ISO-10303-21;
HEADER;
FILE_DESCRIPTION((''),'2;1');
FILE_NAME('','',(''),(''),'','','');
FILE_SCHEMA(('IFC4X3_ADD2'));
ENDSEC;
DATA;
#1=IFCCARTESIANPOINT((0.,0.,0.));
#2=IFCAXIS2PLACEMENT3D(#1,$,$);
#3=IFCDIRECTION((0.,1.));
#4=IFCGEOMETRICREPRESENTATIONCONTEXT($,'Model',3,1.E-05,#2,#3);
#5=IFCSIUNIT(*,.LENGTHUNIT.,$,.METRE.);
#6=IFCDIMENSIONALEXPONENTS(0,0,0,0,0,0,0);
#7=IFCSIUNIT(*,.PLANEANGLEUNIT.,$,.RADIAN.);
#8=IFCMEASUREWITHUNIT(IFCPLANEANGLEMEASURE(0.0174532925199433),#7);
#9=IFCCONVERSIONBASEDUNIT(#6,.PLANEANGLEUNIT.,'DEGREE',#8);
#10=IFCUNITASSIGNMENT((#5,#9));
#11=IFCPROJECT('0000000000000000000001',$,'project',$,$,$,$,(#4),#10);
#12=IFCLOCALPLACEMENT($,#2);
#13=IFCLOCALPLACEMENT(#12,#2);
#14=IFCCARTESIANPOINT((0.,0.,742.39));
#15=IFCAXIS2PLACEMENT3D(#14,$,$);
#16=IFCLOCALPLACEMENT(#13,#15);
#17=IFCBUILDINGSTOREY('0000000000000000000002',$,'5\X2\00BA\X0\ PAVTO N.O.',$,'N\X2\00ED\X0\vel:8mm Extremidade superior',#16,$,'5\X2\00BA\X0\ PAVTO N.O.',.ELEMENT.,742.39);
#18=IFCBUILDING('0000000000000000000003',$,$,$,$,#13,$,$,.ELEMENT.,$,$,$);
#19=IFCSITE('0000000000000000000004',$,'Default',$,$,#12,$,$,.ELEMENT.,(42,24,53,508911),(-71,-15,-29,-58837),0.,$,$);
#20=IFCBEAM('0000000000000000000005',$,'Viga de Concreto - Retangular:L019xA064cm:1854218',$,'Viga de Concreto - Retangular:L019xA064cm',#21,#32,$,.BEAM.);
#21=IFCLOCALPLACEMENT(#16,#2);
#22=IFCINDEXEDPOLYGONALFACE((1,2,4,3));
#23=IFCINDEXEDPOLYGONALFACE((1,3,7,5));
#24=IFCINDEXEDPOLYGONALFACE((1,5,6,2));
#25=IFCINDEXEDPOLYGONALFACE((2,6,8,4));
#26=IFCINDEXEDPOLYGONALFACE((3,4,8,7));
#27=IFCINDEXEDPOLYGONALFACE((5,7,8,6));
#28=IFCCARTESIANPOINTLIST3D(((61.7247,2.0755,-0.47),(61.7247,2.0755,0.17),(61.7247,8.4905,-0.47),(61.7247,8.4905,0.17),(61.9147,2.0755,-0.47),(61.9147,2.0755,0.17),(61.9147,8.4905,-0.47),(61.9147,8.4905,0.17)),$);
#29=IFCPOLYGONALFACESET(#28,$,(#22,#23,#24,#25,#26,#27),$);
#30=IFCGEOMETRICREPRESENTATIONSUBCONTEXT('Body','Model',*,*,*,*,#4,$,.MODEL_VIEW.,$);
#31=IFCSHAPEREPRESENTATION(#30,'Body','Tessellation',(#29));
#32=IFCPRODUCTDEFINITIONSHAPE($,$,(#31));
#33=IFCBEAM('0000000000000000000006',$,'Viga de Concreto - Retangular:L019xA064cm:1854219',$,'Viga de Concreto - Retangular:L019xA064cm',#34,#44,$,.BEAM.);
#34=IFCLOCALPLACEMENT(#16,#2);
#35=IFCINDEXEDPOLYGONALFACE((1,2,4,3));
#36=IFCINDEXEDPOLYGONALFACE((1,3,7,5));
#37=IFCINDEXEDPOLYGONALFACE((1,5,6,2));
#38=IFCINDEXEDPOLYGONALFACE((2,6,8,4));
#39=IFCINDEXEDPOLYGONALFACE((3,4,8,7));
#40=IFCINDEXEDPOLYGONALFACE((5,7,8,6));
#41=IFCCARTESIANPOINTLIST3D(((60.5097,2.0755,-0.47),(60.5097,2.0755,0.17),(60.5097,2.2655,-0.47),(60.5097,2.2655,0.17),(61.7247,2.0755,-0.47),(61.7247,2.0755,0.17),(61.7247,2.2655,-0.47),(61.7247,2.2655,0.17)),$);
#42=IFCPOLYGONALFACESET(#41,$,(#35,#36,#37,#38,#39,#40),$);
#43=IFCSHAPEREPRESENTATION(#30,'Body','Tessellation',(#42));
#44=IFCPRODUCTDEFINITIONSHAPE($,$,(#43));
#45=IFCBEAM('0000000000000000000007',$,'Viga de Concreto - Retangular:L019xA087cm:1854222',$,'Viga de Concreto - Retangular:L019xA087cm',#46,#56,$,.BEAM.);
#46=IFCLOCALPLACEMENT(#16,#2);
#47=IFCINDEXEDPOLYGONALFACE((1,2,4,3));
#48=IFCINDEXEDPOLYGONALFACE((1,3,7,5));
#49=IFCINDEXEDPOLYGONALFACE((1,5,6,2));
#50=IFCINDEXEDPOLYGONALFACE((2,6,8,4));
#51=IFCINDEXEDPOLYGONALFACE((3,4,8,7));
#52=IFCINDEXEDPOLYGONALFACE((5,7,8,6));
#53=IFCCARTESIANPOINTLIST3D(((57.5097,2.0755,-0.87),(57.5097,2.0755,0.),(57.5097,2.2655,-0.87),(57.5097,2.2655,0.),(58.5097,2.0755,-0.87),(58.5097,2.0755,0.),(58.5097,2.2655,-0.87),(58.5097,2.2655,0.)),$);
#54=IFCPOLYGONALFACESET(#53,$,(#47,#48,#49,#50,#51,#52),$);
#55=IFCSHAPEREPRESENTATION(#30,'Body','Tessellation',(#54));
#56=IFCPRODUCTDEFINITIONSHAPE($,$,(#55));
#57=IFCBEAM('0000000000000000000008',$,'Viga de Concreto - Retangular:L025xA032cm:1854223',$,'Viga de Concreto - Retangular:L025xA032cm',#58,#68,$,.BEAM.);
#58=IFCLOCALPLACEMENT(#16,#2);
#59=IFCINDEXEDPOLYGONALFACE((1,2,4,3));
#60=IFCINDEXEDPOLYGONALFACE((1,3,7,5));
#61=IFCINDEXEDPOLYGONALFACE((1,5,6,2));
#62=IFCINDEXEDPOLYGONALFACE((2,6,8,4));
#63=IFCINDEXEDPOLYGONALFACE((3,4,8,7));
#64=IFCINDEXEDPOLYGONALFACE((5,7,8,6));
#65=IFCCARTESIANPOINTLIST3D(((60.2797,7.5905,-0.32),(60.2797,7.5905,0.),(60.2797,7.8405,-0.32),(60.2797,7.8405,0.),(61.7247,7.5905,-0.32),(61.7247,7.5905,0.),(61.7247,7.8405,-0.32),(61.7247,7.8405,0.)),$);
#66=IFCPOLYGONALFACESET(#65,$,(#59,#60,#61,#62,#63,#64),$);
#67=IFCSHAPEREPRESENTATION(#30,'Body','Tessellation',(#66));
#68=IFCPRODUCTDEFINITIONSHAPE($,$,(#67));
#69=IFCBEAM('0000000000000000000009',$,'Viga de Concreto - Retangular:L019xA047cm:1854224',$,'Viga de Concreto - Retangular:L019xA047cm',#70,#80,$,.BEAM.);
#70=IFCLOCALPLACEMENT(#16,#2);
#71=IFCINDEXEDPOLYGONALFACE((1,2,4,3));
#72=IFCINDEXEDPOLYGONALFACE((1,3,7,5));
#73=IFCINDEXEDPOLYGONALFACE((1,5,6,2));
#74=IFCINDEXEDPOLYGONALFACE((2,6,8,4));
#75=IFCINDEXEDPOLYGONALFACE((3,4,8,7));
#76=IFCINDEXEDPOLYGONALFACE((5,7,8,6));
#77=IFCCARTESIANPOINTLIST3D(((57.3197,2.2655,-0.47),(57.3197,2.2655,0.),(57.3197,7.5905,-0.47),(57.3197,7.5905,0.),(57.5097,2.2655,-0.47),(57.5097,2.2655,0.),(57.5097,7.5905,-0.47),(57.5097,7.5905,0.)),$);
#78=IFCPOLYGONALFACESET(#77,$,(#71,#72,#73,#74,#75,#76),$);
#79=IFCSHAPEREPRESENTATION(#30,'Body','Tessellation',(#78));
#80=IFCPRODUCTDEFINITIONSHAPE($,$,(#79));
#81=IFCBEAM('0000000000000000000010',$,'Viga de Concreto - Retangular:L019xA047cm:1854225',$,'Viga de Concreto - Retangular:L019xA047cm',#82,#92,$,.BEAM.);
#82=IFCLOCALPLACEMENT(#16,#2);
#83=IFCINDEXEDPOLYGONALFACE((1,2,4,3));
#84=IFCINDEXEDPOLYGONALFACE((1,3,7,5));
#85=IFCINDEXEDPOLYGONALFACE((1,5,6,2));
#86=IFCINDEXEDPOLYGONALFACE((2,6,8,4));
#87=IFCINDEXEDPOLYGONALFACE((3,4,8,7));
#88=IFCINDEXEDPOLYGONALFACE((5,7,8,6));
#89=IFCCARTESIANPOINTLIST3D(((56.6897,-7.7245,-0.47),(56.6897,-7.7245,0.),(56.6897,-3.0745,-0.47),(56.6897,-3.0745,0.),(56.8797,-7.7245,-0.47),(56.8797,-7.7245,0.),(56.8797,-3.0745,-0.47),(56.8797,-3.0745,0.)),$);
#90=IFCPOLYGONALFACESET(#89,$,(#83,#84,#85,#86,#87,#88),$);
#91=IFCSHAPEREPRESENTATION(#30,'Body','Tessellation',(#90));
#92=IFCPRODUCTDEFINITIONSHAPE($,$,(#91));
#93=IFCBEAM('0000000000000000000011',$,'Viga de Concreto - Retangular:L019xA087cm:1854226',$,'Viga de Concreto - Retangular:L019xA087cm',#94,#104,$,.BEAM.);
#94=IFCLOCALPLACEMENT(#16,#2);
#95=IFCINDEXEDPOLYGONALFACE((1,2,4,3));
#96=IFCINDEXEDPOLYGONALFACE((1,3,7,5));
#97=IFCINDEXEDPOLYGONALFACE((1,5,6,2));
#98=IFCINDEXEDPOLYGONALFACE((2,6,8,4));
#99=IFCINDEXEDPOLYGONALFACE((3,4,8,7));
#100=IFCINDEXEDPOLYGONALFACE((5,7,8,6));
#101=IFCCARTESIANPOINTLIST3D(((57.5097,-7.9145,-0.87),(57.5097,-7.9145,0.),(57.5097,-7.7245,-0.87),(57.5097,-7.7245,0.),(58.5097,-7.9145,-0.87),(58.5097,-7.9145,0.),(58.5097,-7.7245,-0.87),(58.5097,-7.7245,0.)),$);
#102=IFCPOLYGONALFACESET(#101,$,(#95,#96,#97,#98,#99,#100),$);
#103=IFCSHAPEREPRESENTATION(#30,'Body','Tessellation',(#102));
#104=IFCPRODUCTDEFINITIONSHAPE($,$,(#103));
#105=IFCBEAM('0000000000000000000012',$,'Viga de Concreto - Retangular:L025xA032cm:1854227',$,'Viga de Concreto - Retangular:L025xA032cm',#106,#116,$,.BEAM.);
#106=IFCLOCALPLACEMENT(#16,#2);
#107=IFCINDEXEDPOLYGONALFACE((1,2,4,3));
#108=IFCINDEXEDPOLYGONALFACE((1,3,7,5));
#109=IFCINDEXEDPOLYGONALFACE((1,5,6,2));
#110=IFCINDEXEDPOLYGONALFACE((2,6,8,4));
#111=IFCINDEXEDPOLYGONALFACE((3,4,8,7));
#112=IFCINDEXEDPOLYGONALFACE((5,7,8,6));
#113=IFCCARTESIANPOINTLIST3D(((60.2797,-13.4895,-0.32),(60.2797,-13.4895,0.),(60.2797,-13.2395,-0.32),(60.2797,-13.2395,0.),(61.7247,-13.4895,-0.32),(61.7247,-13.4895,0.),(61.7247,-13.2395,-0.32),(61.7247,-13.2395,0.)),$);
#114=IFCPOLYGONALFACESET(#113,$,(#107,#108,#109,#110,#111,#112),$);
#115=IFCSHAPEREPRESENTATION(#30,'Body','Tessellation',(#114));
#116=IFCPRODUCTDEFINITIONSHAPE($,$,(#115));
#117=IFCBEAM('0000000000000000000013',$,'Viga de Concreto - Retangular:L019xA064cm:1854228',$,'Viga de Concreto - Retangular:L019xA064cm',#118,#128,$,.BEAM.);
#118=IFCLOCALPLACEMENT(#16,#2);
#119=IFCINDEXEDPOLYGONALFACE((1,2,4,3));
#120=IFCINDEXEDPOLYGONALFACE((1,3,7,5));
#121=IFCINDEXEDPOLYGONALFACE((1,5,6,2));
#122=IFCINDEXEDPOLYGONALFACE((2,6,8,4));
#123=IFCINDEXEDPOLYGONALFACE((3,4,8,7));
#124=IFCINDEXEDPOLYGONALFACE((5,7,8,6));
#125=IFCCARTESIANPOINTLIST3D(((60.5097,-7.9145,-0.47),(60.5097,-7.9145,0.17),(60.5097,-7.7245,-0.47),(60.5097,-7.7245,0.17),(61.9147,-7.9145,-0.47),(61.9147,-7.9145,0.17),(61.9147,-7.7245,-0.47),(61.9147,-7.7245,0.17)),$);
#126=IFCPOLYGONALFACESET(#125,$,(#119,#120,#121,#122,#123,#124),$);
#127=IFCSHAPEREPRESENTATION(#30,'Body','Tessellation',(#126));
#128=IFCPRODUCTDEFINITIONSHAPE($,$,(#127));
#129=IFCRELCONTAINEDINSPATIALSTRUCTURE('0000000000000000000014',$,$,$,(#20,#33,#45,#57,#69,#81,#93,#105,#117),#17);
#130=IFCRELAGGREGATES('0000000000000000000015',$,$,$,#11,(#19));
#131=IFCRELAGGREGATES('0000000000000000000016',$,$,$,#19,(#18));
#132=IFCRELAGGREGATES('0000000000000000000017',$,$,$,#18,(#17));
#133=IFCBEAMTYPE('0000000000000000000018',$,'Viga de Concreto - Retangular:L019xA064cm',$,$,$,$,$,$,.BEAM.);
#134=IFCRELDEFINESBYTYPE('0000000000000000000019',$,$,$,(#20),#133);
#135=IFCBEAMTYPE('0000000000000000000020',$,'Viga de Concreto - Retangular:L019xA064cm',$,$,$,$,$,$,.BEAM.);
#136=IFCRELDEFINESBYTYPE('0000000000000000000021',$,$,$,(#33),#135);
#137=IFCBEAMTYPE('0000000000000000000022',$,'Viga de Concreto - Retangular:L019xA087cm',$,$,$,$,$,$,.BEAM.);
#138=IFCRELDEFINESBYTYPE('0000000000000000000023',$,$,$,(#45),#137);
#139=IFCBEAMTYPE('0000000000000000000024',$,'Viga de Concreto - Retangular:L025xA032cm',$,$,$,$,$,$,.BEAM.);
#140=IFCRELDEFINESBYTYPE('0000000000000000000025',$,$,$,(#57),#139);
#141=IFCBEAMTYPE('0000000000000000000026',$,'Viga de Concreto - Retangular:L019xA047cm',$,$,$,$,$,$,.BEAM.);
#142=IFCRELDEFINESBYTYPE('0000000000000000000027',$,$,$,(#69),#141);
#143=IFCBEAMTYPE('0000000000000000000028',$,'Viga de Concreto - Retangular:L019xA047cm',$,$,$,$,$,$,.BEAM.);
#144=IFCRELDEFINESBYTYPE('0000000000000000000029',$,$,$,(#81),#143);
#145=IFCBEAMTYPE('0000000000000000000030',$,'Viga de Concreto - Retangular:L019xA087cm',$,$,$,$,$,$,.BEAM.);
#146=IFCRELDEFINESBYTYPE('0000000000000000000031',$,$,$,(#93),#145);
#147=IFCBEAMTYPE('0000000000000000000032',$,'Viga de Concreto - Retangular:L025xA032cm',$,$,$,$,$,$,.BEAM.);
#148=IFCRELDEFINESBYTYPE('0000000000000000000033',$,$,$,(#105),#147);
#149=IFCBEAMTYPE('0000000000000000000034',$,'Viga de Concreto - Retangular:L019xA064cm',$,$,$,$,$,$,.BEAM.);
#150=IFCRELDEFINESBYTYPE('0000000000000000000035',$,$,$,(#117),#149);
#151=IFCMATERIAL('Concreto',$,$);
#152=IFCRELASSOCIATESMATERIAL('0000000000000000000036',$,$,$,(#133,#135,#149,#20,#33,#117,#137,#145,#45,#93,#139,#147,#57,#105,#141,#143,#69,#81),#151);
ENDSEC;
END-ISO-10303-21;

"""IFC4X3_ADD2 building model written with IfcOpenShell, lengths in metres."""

from ifc_helpers import new_model, entity, si_unit, converted_unit, direction, frame, frame_2d, origin, origin_2d_with_axis, place, context, subcontext, project, spatial, rectangle, extrude, source, transform, mapped, material, material_profile, profile_set, profile_usage, type_object, type_shapes, element, save


model = new_model("IFC4X3_ADD2")

# Units and contexts
model_context = context("Model", 3, precision=1e-05, world=origin(), true_north=direction((0.0, 1.0)))
body_context = subcontext(model_context, "Body", "Model", "MODEL_VIEW")
ifc_project = project(units=[si_unit("LENGTHUNIT", "METRE"), converted_unit("PLANEANGLEUNIT", "DEGREE", entity("IfcPlaneAngleMeasure", 0.0174532925199433), si_unit("PLANEANGLEUNIT", "RADIAN"), dimensions=[0, 0, 0, 0, 0, 0, 0])], contexts=[model_context])

# Site, building, storey
site_placement = place(None, origin())
site = spatial("IfcSite", under=ifc_project, at=site_placement, Name="Default", CompositionType="ELEMENT", RefLatitude=(42, 24, 53, 508911), RefLongitude=(-71, -15, -29, -58837), RefElevation=0.0)
building_placement = place(site_placement, origin())
building = spatial("IfcBuilding", under=site, at=building_placement, CompositionType="ELEMENT")
storey_placement = place(building_placement, frame((0.0, 0.0, 742.39)))
storey = spatial("IfcBuildingStorey", under=building, at=storey_placement, Name="5º PAVTO N.O.", ObjectType="Nível:8mm Extremidade superior", LongName="5º PAVTO N.O.", CompositionType="ELEMENT", Elevation=742.39)

# Shared definitions
ifc_material = material(Name="Concreto")

# Beams
ifc_material_profile_1 = material_profile(ifc_material, rectangle(XDim=0.64, YDim=0.19, at=frame_2d((0.0, 0.0), x_axis=(1.0, 0.0))), Name="L019xA064cm")
ifc_profile_set_1 = profile_set([ifc_material_profile_1], Name="L019xA064cm")
ifc_profile_usage_1 = profile_usage(ifc_profile_set_1, cardinal=8)
beam_type_1 = type_object("IfcBeamType", Name="Viga de Concreto - Retangular:L019xA064cm", PredefinedType="BEAM", material=ifc_profile_set_1)
shared_shape_1 = source(origin(), body_context, "Body", "SweptSolid", [
    extrude(rectangle(XDim=0.64, YDim=0.19, at=frame_2d((0.0, 0.0), x_axis=(0.0, 1.0))), frame((61.8197, 8.4905, 742.24), z_axis=(0.0, -1.0, 0.0), x_axis=(-1.0, 0.0, 0.0)), (0.0, 0.0, 1.0), 6.415),
])
type_shapes(beam_type_1, [shared_shape_1])
beam_1_placement = place(storey_placement, frame((0.0, 0.0, -742.39)))
element("IfcBeam", 1, at=beam_1_placement, inside=storey, type_object=beam_type_1, material=ifc_profile_usage_1, Name="Viga de Concreto - Retangular:L019xA064cm:1854218", ObjectType="Viga de Concreto - Retangular:L019xA064cm", PredefinedType="BEAM", context=body_context, shape_type="MappedRepresentation", body=[
    mapped(shared_shape_1, transform((0.0, 0.0, 0.0), scale=1.0)),
])
beam_type_2 = type_object("IfcBeamType", Name="Viga de Concreto - Retangular:L019xA064cm", PredefinedType="BEAM", material=ifc_profile_set_1)
shared_shape_2 = source(origin(), body_context, "Body", "SweptSolid", [
    extrude(rectangle(XDim=0.64, YDim=0.19, at=frame_2d((0.0, 0.0), x_axis=(1.0, 0.0))), frame((60.5097, 2.1705, 742.24), z_axis=(1.0, 0.0, 0.0), x_axis=(0.0, 0.0, -1.0)), (0.0, 0.0, 1.0), 1.215),
])
type_shapes(beam_type_2, [shared_shape_2])
beam_2_placement = place(storey_placement, frame((0.0, 0.0, -742.39)))
element("IfcBeam", 2, at=beam_2_placement, inside=storey, type_object=beam_type_2, material=ifc_profile_usage_1, Name="Viga de Concreto - Retangular:L019xA064cm:1854219", ObjectType="Viga de Concreto - Retangular:L019xA064cm", PredefinedType="BEAM", context=body_context, shape_type="MappedRepresentation", body=[
    mapped(shared_shape_2, transform((0.0, 0.0, 0.0), scale=1.0)),
])
ifc_material_profile_2 = material_profile(ifc_material, rectangle(XDim=0.87, YDim=0.19, at=origin_2d_with_axis()), Name="L019xA087cm")
ifc_profile_set_2 = profile_set([ifc_material_profile_2], Name="L019xA087cm")
ifc_profile_usage_2 = profile_usage(ifc_profile_set_2, cardinal=8)
beam_type_3 = type_object("IfcBeamType", Name="Viga de Concreto - Retangular:L019xA087cm", PredefinedType="BEAM", material=ifc_profile_set_2)
shared_shape_3 = source(origin(), body_context, "Body", "SweptSolid", [
    extrude(rectangle(XDim=0.87, YDim=0.19, at=origin_2d_with_axis()), frame((57.5097, 2.1705, 741.955), z_axis=(1.0, 0.0, 0.0), x_axis=(0.0, 0.0, -1.0)), (0.0, 0.0, 1.0), 1.0),
])
type_shapes(beam_type_3, [shared_shape_3])
beam_3_placement = place(storey_placement, frame((0.0, 0.0, -742.39)))
element("IfcBeam", 3, at=beam_3_placement, inside=storey, type_object=beam_type_3, material=ifc_profile_usage_2, Name="Viga de Concreto - Retangular:L019xA087cm:1854222", ObjectType="Viga de Concreto - Retangular:L019xA087cm", PredefinedType="BEAM", context=body_context, shape_type="MappedRepresentation", body=[
    mapped(shared_shape_3, transform((0.0, 0.0, 0.0), scale=1.0)),
])
ifc_material_profile_3 = material_profile(ifc_material, rectangle(XDim=0.32, YDim=0.25, at=frame_2d((0.0, 0.0), x_axis=(1.0, 0.0))), Name="L025xA032cm")
ifc_profile_set_3 = profile_set([ifc_material_profile_3], Name="L025xA032cm")
ifc_profile_usage_3 = profile_usage(ifc_profile_set_3, cardinal=8)
beam_type_4 = type_object("IfcBeamType", Name="Viga de Concreto - Retangular:L025xA032cm", PredefinedType="BEAM", material=ifc_profile_set_3)
shared_shape_4 = source(origin(), body_context, "Body", "SweptSolid", [
    extrude(rectangle(XDim=0.32, YDim=0.25, at=frame_2d((0.0, 0.0), x_axis=(1.0, 0.0))), frame((60.2797, 7.7155, 742.23), z_axis=(1.0, 0.0, 0.0), x_axis=(0.0, 0.0, -1.0)), (0.0, 0.0, 1.0), 1.445),
])
type_shapes(beam_type_4, [shared_shape_4])
beam_4_placement = place(storey_placement, frame((0.0, 0.0, -742.39)))
element("IfcBeam", 4, at=beam_4_placement, inside=storey, type_object=beam_type_4, material=ifc_profile_usage_3, Name="Viga de Concreto - Retangular:L025xA032cm:1854223", ObjectType="Viga de Concreto - Retangular:L025xA032cm", PredefinedType="BEAM", context=body_context, shape_type="MappedRepresentation", body=[
    mapped(shared_shape_4, transform((0.0, 0.0, 0.0), scale=1.0)),
])
ifc_material_profile_4 = material_profile(ifc_material, rectangle(XDim=0.47, YDim=0.19, at=frame_2d((0.0, 0.0), x_axis=(0.0, 1.0))), Name="L019xA047cm")
ifc_profile_set_4 = profile_set([ifc_material_profile_4], Name="L019xA047cm")
ifc_profile_usage_4 = profile_usage(ifc_profile_set_4, cardinal=8)
beam_type_5 = type_object("IfcBeamType", Name="Viga de Concreto - Retangular:L019xA047cm", PredefinedType="BEAM", material=ifc_profile_set_4)
shared_shape_5 = source(origin(), body_context, "Body", "SweptSolid", [
    extrude(rectangle(XDim=0.47, YDim=0.19, at=frame_2d((0.0, 0.0), x_axis=(0.0, 1.0))), frame((57.4147, 2.2655, 742.155), z_axis=(0.0, 1.0, 0.0), x_axis=(-1.0, 0.0, 0.0)), (0.0, 0.0, 1.0), 5.325),
])
type_shapes(beam_type_5, [shared_shape_5])
beam_5_placement = place(storey_placement, frame((0.0, 0.0, -742.39)))
element("IfcBeam", 5, at=beam_5_placement, inside=storey, type_object=beam_type_5, material=ifc_profile_usage_4, Name="Viga de Concreto - Retangular:L019xA047cm:1854224", ObjectType="Viga de Concreto - Retangular:L019xA047cm", PredefinedType="BEAM", context=body_context, shape_type="MappedRepresentation", body=[
    mapped(shared_shape_5, transform((0.0, 0.0, 0.0), scale=1.0)),
])
beam_type_6 = type_object("IfcBeamType", Name="Viga de Concreto - Retangular:L019xA047cm", PredefinedType="BEAM", material=ifc_profile_set_4)
shared_shape_6 = source(origin(), body_context, "Body", "SweptSolid", [
    extrude(rectangle(XDim=0.47, YDim=0.19, at=frame_2d((0.0, 0.0), x_axis=(0.0, 1.0))), frame((56.7847, -7.7245, 742.155), z_axis=(0.0, 1.0, 0.0), x_axis=(-1.0, 0.0, 0.0)), (0.0, 0.0, 1.0), 4.65),
])
type_shapes(beam_type_6, [shared_shape_6])
beam_6_placement = place(storey_placement, frame((0.0, 0.0, -742.39)))
element("IfcBeam", 6, at=beam_6_placement, inside=storey, type_object=beam_type_6, material=ifc_profile_usage_4, Name="Viga de Concreto - Retangular:L019xA047cm:1854225", ObjectType="Viga de Concreto - Retangular:L019xA047cm", PredefinedType="BEAM", context=body_context, shape_type="MappedRepresentation", body=[
    mapped(shared_shape_6, transform((0.0, 0.0, 0.0), scale=1.0)),
])
beam_type_7 = type_object("IfcBeamType", Name="Viga de Concreto - Retangular:L019xA087cm", PredefinedType="BEAM", material=ifc_profile_set_2)
shared_shape_7 = source(origin(), body_context, "Body", "SweptSolid", [
    extrude(rectangle(XDim=0.87, YDim=0.19, at=frame_2d((0.0, 0.0), x_axis=(1.0, 0.0))), frame((57.5097, -7.8195, 741.955), z_axis=(1.0, 0.0, 0.0), x_axis=(0.0, 0.0, -1.0)), (0.0, 0.0, 1.0), 1.0),
])
type_shapes(beam_type_7, [shared_shape_7])
beam_7_placement = place(storey_placement, frame((0.0, 0.0, -742.39)))
element("IfcBeam", 7, at=beam_7_placement, inside=storey, type_object=beam_type_7, material=ifc_profile_usage_2, Name="Viga de Concreto - Retangular:L019xA087cm:1854226", ObjectType="Viga de Concreto - Retangular:L019xA087cm", PredefinedType="BEAM", context=body_context, shape_type="MappedRepresentation", body=[
    mapped(shared_shape_7, transform((0.0, 0.0, 0.0), scale=1.0)),
])
beam_type_8 = type_object("IfcBeamType", Name="Viga de Concreto - Retangular:L025xA032cm", PredefinedType="BEAM", material=ifc_profile_set_3)
shared_shape_8 = source(origin(), body_context, "Body", "SweptSolid", [
    extrude(rectangle(XDim=0.32, YDim=0.25, at=origin_2d_with_axis()), frame((60.2797, -13.3645, 742.23), z_axis=(1.0, 0.0, 0.0), x_axis=(0.0, 0.0, -1.0)), (0.0, 0.0, 1.0), 1.445),
])
type_shapes(beam_type_8, [shared_shape_8])
beam_8_placement = place(storey_placement, frame((0.0, 0.0, -742.39)))
element("IfcBeam", 8, at=beam_8_placement, inside=storey, type_object=beam_type_8, material=ifc_profile_usage_3, Name="Viga de Concreto - Retangular:L025xA032cm:1854227", ObjectType="Viga de Concreto - Retangular:L025xA032cm", PredefinedType="BEAM", context=body_context, shape_type="MappedRepresentation", body=[
    mapped(shared_shape_8, transform((0.0, 0.0, 0.0), scale=1.0)),
])
beam_type_9 = type_object("IfcBeamType", Name="Viga de Concreto - Retangular:L019xA064cm", PredefinedType="BEAM", material=ifc_profile_set_1)
shared_shape_9 = source(origin(), body_context, "Body", "SweptSolid", [
    extrude(rectangle(XDim=0.64, YDim=0.19, at=frame_2d((0.0, 0.0), x_axis=(1.0, 0.0))), frame((60.5097, -7.8195, 742.24), z_axis=(1.0, 0.0, 0.0), x_axis=(0.0, 0.0, -1.0)), (0.0, 0.0, 1.0), 1.405),
])
type_shapes(beam_type_9, [shared_shape_9])
beam_9_placement = place(storey_placement, frame((0.0, 0.0, -742.39)))
element("IfcBeam", 9, at=beam_9_placement, inside=storey, type_object=beam_type_9, material=ifc_profile_usage_1, Name="Viga de Concreto - Retangular:L019xA064cm:1854228", ObjectType="Viga de Concreto - Retangular:L019xA064cm", PredefinedType="BEAM", context=body_context, shape_type="MappedRepresentation", body=[
    mapped(shared_shape_9, transform((0.0, 0.0, 0.0), scale=1.0)),
])

save(model, "model.ifc")
